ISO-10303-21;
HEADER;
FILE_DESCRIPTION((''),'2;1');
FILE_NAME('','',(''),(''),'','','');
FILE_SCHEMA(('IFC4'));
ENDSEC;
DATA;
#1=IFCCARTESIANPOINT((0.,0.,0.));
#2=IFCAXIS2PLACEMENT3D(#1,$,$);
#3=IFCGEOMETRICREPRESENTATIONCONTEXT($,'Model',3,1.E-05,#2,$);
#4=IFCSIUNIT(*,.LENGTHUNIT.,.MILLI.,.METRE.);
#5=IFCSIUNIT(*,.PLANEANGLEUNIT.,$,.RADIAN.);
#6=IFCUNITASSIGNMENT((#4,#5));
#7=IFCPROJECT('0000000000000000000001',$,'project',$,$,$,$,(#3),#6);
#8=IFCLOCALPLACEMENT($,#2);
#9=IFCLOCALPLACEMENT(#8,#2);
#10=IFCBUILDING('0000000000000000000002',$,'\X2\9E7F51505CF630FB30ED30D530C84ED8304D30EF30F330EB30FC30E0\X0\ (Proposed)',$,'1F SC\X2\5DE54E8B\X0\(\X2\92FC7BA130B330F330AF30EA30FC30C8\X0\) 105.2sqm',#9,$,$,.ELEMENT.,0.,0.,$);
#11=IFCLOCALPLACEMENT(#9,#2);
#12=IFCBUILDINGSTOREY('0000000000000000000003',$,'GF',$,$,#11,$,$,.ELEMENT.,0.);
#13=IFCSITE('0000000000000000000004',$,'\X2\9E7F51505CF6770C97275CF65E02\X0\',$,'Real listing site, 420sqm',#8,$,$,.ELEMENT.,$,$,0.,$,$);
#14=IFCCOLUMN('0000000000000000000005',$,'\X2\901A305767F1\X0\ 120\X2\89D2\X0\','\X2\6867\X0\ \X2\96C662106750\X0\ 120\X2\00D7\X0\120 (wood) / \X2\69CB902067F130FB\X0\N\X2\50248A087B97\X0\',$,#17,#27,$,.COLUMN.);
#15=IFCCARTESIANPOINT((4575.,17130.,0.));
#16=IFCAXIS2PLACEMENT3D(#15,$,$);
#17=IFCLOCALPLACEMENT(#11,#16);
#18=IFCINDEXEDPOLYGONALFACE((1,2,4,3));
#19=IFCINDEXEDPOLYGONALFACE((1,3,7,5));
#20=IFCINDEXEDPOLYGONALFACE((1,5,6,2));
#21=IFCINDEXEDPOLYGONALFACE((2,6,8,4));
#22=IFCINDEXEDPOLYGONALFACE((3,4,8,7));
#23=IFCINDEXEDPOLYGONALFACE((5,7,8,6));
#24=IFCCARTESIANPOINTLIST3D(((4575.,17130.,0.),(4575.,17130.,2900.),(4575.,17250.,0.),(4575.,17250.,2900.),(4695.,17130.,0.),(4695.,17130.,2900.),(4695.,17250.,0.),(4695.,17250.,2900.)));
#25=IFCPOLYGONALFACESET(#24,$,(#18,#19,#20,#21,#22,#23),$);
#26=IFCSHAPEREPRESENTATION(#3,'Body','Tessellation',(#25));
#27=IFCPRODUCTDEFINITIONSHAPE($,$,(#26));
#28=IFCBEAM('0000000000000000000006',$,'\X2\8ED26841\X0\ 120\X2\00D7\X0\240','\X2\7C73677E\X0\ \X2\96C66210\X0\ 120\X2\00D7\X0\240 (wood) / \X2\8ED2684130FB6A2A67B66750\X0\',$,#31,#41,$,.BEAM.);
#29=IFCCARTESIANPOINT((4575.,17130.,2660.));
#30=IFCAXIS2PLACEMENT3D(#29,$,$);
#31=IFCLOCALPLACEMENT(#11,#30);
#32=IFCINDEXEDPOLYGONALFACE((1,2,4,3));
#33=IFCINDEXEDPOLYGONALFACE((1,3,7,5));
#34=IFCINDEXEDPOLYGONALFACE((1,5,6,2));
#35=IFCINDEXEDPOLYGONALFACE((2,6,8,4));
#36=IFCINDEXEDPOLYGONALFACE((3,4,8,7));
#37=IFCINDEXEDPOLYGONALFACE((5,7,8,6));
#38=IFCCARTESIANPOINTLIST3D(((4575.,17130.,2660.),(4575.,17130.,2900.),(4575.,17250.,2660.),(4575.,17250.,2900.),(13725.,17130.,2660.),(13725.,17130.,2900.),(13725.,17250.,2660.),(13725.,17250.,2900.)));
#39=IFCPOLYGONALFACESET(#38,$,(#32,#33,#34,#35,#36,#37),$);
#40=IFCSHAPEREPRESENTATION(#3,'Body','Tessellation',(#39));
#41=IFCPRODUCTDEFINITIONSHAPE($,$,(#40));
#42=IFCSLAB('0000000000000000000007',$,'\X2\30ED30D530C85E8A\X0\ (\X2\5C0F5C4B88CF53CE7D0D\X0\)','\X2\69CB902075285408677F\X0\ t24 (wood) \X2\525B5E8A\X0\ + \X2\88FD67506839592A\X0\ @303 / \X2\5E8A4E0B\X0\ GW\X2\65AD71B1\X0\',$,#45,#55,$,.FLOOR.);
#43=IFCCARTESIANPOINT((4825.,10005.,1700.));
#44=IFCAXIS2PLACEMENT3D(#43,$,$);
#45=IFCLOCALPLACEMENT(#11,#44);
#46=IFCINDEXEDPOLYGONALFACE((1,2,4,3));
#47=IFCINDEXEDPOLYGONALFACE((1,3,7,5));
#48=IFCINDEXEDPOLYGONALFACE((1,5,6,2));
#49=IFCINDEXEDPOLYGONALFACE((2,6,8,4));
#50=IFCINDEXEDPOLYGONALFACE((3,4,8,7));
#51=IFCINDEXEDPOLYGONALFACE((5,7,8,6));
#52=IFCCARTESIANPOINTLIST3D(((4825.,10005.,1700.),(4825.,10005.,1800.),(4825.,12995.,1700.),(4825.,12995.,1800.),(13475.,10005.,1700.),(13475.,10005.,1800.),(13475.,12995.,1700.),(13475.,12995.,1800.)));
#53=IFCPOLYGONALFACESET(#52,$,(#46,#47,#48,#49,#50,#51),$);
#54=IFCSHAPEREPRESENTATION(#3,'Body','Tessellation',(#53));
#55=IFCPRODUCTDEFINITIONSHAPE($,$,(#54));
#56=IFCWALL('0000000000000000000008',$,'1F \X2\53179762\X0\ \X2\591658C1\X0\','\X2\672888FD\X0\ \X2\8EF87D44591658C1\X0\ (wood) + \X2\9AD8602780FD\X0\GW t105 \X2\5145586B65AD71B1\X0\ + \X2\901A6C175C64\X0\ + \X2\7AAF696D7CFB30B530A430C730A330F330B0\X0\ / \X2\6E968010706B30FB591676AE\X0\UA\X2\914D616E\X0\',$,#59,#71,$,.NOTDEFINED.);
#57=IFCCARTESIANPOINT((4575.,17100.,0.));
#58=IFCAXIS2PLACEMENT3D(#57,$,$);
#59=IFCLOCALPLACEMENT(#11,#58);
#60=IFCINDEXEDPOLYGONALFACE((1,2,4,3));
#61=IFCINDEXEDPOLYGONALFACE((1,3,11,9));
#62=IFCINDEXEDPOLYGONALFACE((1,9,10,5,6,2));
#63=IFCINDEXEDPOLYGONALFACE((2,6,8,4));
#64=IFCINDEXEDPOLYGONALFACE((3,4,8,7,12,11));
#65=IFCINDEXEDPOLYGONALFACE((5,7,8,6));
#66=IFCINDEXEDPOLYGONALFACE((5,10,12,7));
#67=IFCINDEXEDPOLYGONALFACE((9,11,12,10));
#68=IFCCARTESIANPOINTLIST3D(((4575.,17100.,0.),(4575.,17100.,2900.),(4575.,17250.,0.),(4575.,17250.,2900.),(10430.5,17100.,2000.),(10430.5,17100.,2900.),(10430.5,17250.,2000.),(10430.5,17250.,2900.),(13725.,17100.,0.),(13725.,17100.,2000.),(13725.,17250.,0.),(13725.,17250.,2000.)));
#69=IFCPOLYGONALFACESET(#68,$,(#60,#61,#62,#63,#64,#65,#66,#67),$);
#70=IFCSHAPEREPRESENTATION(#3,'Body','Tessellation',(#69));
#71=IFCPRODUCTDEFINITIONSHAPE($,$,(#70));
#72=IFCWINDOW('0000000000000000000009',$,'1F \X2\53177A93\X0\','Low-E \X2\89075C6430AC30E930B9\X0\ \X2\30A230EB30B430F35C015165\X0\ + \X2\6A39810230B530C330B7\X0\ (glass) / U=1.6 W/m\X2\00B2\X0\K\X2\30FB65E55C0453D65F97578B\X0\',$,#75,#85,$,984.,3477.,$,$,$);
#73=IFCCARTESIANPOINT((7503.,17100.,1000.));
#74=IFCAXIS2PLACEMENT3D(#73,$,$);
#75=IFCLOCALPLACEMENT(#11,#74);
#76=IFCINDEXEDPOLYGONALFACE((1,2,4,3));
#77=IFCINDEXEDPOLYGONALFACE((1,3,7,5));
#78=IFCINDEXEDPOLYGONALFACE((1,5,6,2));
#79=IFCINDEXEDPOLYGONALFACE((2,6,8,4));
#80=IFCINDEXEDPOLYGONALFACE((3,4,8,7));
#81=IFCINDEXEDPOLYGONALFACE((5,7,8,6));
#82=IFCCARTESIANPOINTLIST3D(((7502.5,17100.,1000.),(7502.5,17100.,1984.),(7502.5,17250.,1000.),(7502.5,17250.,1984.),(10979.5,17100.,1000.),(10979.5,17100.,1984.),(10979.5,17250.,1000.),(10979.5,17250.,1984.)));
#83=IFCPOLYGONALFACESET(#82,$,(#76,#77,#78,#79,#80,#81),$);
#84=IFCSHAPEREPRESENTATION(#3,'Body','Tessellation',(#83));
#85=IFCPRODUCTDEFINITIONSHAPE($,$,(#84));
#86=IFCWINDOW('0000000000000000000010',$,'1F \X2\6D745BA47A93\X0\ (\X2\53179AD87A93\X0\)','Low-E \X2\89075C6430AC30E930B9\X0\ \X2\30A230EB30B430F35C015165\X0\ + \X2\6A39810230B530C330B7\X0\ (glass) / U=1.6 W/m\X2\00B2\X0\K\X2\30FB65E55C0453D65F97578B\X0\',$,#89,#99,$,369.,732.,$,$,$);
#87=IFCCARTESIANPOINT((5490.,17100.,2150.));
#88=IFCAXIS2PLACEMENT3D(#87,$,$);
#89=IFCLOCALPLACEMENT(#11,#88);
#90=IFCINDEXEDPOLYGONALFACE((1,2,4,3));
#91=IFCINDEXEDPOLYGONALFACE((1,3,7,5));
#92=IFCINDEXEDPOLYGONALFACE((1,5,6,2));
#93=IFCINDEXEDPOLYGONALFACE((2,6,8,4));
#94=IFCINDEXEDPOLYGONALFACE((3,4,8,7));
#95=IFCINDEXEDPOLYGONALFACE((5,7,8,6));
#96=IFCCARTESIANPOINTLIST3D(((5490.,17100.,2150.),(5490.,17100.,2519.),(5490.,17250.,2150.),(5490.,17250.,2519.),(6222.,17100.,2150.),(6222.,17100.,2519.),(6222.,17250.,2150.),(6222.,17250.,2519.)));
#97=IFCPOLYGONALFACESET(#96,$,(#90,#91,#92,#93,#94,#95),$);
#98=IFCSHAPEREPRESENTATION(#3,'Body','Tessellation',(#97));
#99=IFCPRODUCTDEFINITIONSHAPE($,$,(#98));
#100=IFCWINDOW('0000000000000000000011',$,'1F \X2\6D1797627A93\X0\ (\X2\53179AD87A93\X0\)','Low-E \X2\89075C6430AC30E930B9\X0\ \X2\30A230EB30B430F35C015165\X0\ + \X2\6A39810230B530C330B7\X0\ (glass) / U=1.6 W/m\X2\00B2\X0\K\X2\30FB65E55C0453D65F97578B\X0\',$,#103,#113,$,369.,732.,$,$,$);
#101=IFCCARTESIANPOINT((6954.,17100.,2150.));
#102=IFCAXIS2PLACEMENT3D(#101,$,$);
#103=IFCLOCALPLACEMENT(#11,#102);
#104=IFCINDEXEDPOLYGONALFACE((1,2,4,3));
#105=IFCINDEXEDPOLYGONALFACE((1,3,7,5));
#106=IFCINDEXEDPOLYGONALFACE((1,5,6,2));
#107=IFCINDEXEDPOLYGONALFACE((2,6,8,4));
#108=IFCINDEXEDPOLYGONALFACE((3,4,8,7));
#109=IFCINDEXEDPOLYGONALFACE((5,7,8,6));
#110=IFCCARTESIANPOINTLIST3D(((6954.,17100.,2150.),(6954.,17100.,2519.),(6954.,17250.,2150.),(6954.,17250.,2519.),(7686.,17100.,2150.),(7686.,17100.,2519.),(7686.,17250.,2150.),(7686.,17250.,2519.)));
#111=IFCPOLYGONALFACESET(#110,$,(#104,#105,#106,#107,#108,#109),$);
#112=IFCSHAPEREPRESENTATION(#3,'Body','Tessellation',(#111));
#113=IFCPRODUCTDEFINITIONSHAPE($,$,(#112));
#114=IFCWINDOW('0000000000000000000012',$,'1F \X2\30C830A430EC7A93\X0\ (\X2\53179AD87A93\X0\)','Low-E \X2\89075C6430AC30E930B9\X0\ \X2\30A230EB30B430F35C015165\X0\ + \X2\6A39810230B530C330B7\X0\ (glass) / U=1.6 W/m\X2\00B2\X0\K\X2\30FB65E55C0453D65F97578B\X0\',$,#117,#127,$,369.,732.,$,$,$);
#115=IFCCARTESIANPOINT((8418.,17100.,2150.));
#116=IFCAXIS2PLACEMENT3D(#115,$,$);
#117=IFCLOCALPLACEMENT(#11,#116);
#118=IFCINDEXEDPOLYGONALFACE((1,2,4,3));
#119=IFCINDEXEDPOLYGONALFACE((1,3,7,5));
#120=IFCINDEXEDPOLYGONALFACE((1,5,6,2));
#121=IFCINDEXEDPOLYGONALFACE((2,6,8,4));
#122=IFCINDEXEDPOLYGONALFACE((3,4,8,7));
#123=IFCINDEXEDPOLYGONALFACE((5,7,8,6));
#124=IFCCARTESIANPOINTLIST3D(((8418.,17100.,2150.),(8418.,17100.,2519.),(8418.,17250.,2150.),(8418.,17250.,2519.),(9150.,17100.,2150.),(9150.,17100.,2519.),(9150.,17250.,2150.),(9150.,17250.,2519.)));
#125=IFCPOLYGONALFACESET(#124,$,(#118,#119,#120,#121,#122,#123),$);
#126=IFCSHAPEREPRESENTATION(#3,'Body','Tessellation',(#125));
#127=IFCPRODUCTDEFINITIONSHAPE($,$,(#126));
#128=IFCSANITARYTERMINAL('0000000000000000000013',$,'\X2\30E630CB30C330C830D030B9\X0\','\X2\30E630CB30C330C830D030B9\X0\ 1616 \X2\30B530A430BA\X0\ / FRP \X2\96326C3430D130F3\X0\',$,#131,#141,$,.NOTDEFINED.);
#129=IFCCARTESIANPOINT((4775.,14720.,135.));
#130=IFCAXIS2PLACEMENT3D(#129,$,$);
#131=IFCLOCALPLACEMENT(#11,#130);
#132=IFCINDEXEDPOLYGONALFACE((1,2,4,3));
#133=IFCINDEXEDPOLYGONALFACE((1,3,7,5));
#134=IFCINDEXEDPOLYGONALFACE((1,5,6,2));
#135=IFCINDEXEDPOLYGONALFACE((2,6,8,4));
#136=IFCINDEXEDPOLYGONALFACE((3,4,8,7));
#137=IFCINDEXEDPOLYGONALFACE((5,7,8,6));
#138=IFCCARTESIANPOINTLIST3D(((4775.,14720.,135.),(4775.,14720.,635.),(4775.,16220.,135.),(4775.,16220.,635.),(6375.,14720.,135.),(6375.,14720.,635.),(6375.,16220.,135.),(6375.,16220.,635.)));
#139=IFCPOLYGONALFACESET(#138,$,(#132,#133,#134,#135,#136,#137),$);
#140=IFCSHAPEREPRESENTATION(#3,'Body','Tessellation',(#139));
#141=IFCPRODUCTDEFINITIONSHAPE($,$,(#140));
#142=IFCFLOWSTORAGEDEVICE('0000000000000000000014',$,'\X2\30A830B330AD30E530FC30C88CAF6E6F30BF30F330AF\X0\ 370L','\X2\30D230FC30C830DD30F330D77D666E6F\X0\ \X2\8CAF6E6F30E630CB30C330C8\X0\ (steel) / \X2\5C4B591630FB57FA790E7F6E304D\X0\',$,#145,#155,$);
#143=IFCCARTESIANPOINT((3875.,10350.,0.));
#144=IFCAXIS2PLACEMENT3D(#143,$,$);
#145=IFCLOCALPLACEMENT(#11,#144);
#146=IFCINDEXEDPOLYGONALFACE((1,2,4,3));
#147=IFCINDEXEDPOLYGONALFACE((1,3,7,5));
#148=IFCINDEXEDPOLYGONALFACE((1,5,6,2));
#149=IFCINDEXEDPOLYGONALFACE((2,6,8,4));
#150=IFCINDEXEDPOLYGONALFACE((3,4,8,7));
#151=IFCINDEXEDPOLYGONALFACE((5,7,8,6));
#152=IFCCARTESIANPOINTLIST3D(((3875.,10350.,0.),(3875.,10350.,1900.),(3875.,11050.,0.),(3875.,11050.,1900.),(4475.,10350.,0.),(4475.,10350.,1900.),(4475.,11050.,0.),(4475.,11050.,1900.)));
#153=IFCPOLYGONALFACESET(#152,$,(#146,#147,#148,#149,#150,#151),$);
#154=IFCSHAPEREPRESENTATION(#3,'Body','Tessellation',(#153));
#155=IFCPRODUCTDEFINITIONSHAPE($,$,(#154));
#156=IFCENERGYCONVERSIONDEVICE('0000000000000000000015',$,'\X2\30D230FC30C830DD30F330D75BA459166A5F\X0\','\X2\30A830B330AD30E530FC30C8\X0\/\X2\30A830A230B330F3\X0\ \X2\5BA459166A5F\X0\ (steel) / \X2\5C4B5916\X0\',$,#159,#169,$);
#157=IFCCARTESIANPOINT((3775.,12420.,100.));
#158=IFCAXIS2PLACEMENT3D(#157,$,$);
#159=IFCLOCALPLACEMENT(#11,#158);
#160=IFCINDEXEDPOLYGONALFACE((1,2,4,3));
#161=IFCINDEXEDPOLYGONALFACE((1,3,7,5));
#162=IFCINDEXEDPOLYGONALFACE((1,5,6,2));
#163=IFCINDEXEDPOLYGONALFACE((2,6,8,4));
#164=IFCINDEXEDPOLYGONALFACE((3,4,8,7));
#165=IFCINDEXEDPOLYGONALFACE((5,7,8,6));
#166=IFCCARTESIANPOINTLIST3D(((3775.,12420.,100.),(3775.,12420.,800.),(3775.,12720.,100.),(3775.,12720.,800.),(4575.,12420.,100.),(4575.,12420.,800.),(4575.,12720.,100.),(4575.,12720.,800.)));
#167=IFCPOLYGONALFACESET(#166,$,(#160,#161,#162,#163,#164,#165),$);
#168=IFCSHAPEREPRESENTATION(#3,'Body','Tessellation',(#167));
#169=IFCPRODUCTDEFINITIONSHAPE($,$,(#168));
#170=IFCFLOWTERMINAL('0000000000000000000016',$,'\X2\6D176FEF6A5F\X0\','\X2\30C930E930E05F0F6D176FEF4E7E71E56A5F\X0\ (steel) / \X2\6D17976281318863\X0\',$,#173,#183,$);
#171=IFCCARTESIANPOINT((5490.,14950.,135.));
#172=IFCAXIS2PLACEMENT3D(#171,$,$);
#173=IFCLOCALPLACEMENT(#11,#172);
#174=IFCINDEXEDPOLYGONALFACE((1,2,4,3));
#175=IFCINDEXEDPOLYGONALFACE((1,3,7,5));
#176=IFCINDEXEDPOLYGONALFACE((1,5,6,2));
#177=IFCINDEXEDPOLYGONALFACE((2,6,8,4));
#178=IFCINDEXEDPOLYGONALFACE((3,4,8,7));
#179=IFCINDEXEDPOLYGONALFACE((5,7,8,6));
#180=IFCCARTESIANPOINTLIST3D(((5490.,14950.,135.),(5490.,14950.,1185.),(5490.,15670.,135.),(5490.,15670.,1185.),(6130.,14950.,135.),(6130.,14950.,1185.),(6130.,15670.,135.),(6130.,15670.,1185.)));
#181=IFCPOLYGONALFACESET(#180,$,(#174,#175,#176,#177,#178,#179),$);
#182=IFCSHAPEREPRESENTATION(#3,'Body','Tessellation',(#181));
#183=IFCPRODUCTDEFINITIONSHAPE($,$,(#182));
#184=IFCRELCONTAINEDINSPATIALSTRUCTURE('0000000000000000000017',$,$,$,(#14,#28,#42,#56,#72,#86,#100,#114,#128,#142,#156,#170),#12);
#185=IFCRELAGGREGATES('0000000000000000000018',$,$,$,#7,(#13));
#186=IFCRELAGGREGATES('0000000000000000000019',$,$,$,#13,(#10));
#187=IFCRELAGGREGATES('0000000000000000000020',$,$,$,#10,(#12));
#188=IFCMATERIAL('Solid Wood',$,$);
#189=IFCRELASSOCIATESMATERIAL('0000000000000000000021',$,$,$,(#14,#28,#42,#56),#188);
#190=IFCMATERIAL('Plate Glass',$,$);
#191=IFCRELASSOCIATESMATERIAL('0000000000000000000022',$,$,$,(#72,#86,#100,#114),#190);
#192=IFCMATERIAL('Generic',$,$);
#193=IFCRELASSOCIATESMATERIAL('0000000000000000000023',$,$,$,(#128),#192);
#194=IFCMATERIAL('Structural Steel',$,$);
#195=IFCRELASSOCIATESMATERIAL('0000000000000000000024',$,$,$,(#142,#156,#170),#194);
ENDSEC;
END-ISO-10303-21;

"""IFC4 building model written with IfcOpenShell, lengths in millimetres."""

from ifc_helpers import new_model, si_unit, frame, frame_2d, origin, place, context, project, spatial, rectangle, extrude, material, element, fill, save


model = new_model("IFC4")

# Units and contexts
model_context = context("Model", 3, precision=1e-05, world=origin())
ifc_project = project(units=[si_unit("LENGTHUNIT", "METRE", prefix="MILLI"), si_unit("PLANEANGLEUNIT", "RADIAN")], contexts=[model_context])

# Site, building, storey
site_placement = place(None, origin())
site = spatial("IfcSite", under=ifc_project, at=site_placement, Name="鹿児島県霧島市", ObjectType="Real listing site, 420sqm", CompositionType="ELEMENT", RefElevation=0.0)
building_placement = place(site_placement, origin())
building = spatial("IfcBuilding", under=site, at=building_placement, Name="鹿児島・ロフト付きワンルーム (Proposed)", ObjectType="1F SC工事(鋼管コンクリート) 105.2sqm", CompositionType="ELEMENT", ElevationOfRefHeight=0.0, ElevationOfTerrain=0.0)
storey_placement = place(building_placement, origin())
storey = spatial("IfcBuildingStorey", under=building, at=storey_placement, Name="GF", CompositionType="ELEMENT", Elevation=0.0)

# Column
ifc_material_1 = material(Name="Solid Wood")
column_1_placement = place(storey_placement, frame((4575.0, 17130.0, 0.0)))
element("IfcColumn", 1, at=column_1_placement, inside=storey, material=ifc_material_1, Name="通し柱 120角", Description="桧 集成材 120×120 (wood) / 構造柱・N値計算", PredefinedType="COLUMN", context=model_context, shape_type="SweptSolid", body=[
    extrude(rectangle(XDim=120.0, YDim=120.0, at=frame_2d((60.0, 60.0))), frame((4575.0, 17130.0, 0.0)), (0.0, 0.0, 1.0), 2900.0),
])

# Beam
beam_1_placement = place(storey_placement, frame((4575.0, 17130.0, 2660.0)))
element("IfcBeam", 2, at=beam_1_placement, inside=storey, material=ifc_material_1, Name="軒桁 120×240", Description="米松 集成 120×240 (wood) / 軒桁・横架材", PredefinedType="BEAM", context=model_context, shape_type="SweptSolid", body=[
    extrude(rectangle(XDim=9150.0, YDim=120.0, at=frame_2d((4575.0, 60.0))), frame((4575.0, 17130.0, 2660.0)), (0.0, 0.0, 1.0), 240.0),
])

# Slab
slab_placement = place(storey_placement, frame((4825.0, 10005.0, 1700.0)))
element("IfcSlab", 3, at=slab_placement, inside=storey, material=ifc_material_1, Name="ロフト床 (小屋裏収納)", Description="構造用合板 t24 (wood) 剛床 + 製材根太 @303 / 床下 GW断熱", PredefinedType="FLOOR", context=model_context, shape_type="SweptSolid", body=[
    extrude(rectangle(XDim=8650.0, YDim=2990.0, at=frame_2d((4325.0, 1495.0))), frame((4825.0, 10005.0, 1700.0)), (0.0, 0.0, 1.0), 100.0),
])

# Wall, openings, windows
wall_1_placement = place(storey_placement, frame((4575.0, 17100.0, 0.0)))
wall_1 = element("IfcWall", 4, at=wall_1_placement, inside=storey, material=ifc_material_1, Name="1F 北面 外壁", Description="木製 軸組外壁 (wood) + 高性能GW t105 充填断熱 + 通気層 + 窯業系サイディング / 準耐火・外皮UA配慮", PredefinedType="NOTDEFINED", context=model_context, shape_type="SweptSolid", body=[
    extrude(rectangle(XDim=9150.0, YDim=150.0, at=frame_2d((4575.0, 75.0))), frame((4575.0, 17100.0, 0.0)), (0.0, 0.0, 1.0), 2900.0),
])
opening_1_placement = place(storey_placement, frame((7503.0, 17100.0, 1000.0)))
opening_1 = element("IfcOpeningElement", 5, at=opening_1_placement, cuts=wall_1, PredefinedType="NOTDEFINED", context=model_context, shape_type="SweptSolid", body=[
    extrude(rectangle(XDim=3477.0, YDim=150.0, at=frame_2d((1738.0, 75.0))), frame((7503.0, 17100.0, 1000.0)), (0.0, 0.0, 1.0), 984.0),
])
opening_2_placement = place(storey_placement, frame((5490.0, 17100.0, 2150.0)))
opening_2 = element("IfcOpeningElement", 6, at=opening_2_placement, cuts=wall_1, PredefinedType="NOTDEFINED", context=model_context, shape_type="SweptSolid", body=[
    extrude(rectangle(XDim=732.0, YDim=150.0, at=frame_2d((366.0, 75.0))), frame((5490.0, 17100.0, 2150.0)), (0.0, 0.0, 1.0), 369.0),
])
opening_3_placement = place(storey_placement, frame((6954.0, 17100.0, 2150.0)))
opening_3 = element("IfcOpeningElement", 7, at=opening_3_placement, cuts=wall_1, PredefinedType="NOTDEFINED", context=model_context, shape_type="SweptSolid", body=[
    extrude(rectangle(XDim=732.0, YDim=150.0, at=frame_2d((366.0, 75.0))), frame((6954.0, 17100.0, 2150.0)), (0.0, 0.0, 1.0), 369.0),
])
opening_4_placement = place(storey_placement, frame((8418.0, 17100.0, 2150.0)))
opening_4 = element("IfcOpeningElement", 8, at=opening_4_placement, cuts=wall_1, PredefinedType="NOTDEFINED", context=model_context, shape_type="SweptSolid", body=[
    extrude(rectangle(XDim=732.0, YDim=150.0, at=frame_2d((366.0, 75.0))), frame((8418.0, 17100.0, 2150.0)), (0.0, 0.0, 1.0), 369.0),
])
ifc_material_2 = material(Name="Plate Glass")
window_1_placement = place(storey_placement, frame((7503.0, 17100.0, 1000.0)))
window_1 = element("IfcWindow", 9, at=window_1_placement, inside=storey, material=ifc_material_2, Name="1F 北窓", Description="Low-E 複層ガラス アルゴン封入 + 樹脂サッシ (glass) / U=1.6 W/m²K・日射取得型", OverallHeight=984.0, OverallWidth=3477.0, context=model_context, shape_type="SweptSolid", body=[
    extrude(rectangle(XDim=3477.0, YDim=150.0, at=frame_2d((1738.0, 75.0))), frame((7503.0, 17100.0, 1000.0)), (0.0, 0.0, 1.0), 984.0),
])
fill(opening_1, window_1)
window_2_placement = place(storey_placement, frame((5490.0, 17100.0, 2150.0)))
window_2 = element("IfcWindow", 10, at=window_2_placement, inside=storey, material=ifc_material_2, Name="1F 浴室窓 (北高窓)", Description="Low-E 複層ガラス アルゴン封入 + 樹脂サッシ (glass) / U=1.6 W/m²K・日射取得型", OverallHeight=369.0, OverallWidth=732.0, context=model_context, shape_type="SweptSolid", body=[
    extrude(rectangle(XDim=732.0, YDim=150.0, at=frame_2d((366.0, 75.0))), frame((5490.0, 17100.0, 2150.0)), (0.0, 0.0, 1.0), 369.0),
])
fill(opening_2, window_2)
window_3_placement = place(storey_placement, frame((6954.0, 17100.0, 2150.0)))
window_3 = element("IfcWindow", 11, at=window_3_placement, inside=storey, material=ifc_material_2, Name="1F 洗面窓 (北高窓)", Description="Low-E 複層ガラス アルゴン封入 + 樹脂サッシ (glass) / U=1.6 W/m²K・日射取得型", OverallHeight=369.0, OverallWidth=732.0, context=model_context, shape_type="SweptSolid", body=[
    extrude(rectangle(XDim=732.0, YDim=150.0, at=frame_2d((366.0, 75.0))), frame((6954.0, 17100.0, 2150.0)), (0.0, 0.0, 1.0), 369.0),
])
fill(opening_3, window_3)
window_4_placement = place(storey_placement, frame((8418.0, 17100.0, 2150.0)))
window_4 = element("IfcWindow", 12, at=window_4_placement, inside=storey, material=ifc_material_2, Name="1F トイレ窓 (北高窓)", Description="Low-E 複層ガラス アルゴン封入 + 樹脂サッシ (glass) / U=1.6 W/m²K・日射取得型", OverallHeight=369.0, OverallWidth=732.0, context=model_context, shape_type="SweptSolid", body=[
    extrude(rectangle(XDim=732.0, YDim=150.0, at=frame_2d((366.0, 75.0))), frame((8418.0, 17100.0, 2150.0)), (0.0, 0.0, 1.0), 369.0),
])
fill(opening_4, window_4)

# Sanitary terminal
ifc_material_3 = material(Name="Generic")
sanitary_terminal_placement = place(storey_placement, frame((4775.0, 14720.0, 135.0)))
element("IfcSanitaryTerminal", 13, at=sanitary_terminal_placement, inside=storey, material=ifc_material_3, Name="ユニットバス", Description="ユニットバス 1616 サイズ / FRP 防水パン", PredefinedType="NOTDEFINED", context=model_context, shape_type="SweptSolid", body=[
    extrude(rectangle(XDim=1600.0, YDim=1500.0, at=frame_2d((800.0, 750.0))), frame((4775.0, 14720.0, 135.0)), (0.0, 0.0, 1.0), 500.0),
])

# Flow storage device
ifc_material_4 = material(Name="Structural Steel")
flow_storage_device_placement = place(storey_placement, frame((3875.0, 10350.0, 0.0)))
element("IfcFlowStorageDevice", 14, at=flow_storage_device_placement, inside=storey, material=ifc_material_4, Name="エコキュート貯湯タンク 370L", Description="ヒートポンプ給湯 貯湯ユニット (steel) / 屋外・基礎置き", context=model_context, shape_type="SweptSolid", body=[
    extrude(rectangle(XDim=600.0, YDim=700.0, at=frame_2d((300.0, 350.0))), frame((3875.0, 10350.0, 0.0)), (0.0, 0.0, 1.0), 1900.0),
])

# Energy conversion device
energy_conversion_device_placement = place(storey_placement, frame((3775.0, 12420.0, 100.0)))
element("IfcEnergyConversionDevice", 15, at=energy_conversion_device_placement, inside=storey, material=ifc_material_4, Name="ヒートポンプ室外機", Description="エコキュート/エアコン 室外機 (steel) / 屋外", context=model_context, shape_type="SweptSolid", body=[
    extrude(rectangle(XDim=800.0, YDim=300.0, at=frame_2d((400.0, 150.0))), frame((3775.0, 12420.0, 100.0)), (0.0, 0.0, 1.0), 700.0),
])

# Flow terminal
flow_terminal_placement = place(storey_placement, frame((5490.0, 14950.0, 135.0)))
element("IfcFlowTerminal", 16, at=flow_terminal_placement, inside=storey, material=ifc_material_4, Name="洗濯機", Description="ドラム式洗濯乾燥機 (steel) / 洗面脱衣", context=model_context, shape_type="SweptSolid", body=[
    extrude(rectangle(XDim=640.0, YDim=720.0, at=frame_2d((320.0, 360.0))), frame((5490.0, 14950.0, 135.0)), (0.0, 0.0, 1.0), 1050.0),
])

save(model, "model.ifc")
